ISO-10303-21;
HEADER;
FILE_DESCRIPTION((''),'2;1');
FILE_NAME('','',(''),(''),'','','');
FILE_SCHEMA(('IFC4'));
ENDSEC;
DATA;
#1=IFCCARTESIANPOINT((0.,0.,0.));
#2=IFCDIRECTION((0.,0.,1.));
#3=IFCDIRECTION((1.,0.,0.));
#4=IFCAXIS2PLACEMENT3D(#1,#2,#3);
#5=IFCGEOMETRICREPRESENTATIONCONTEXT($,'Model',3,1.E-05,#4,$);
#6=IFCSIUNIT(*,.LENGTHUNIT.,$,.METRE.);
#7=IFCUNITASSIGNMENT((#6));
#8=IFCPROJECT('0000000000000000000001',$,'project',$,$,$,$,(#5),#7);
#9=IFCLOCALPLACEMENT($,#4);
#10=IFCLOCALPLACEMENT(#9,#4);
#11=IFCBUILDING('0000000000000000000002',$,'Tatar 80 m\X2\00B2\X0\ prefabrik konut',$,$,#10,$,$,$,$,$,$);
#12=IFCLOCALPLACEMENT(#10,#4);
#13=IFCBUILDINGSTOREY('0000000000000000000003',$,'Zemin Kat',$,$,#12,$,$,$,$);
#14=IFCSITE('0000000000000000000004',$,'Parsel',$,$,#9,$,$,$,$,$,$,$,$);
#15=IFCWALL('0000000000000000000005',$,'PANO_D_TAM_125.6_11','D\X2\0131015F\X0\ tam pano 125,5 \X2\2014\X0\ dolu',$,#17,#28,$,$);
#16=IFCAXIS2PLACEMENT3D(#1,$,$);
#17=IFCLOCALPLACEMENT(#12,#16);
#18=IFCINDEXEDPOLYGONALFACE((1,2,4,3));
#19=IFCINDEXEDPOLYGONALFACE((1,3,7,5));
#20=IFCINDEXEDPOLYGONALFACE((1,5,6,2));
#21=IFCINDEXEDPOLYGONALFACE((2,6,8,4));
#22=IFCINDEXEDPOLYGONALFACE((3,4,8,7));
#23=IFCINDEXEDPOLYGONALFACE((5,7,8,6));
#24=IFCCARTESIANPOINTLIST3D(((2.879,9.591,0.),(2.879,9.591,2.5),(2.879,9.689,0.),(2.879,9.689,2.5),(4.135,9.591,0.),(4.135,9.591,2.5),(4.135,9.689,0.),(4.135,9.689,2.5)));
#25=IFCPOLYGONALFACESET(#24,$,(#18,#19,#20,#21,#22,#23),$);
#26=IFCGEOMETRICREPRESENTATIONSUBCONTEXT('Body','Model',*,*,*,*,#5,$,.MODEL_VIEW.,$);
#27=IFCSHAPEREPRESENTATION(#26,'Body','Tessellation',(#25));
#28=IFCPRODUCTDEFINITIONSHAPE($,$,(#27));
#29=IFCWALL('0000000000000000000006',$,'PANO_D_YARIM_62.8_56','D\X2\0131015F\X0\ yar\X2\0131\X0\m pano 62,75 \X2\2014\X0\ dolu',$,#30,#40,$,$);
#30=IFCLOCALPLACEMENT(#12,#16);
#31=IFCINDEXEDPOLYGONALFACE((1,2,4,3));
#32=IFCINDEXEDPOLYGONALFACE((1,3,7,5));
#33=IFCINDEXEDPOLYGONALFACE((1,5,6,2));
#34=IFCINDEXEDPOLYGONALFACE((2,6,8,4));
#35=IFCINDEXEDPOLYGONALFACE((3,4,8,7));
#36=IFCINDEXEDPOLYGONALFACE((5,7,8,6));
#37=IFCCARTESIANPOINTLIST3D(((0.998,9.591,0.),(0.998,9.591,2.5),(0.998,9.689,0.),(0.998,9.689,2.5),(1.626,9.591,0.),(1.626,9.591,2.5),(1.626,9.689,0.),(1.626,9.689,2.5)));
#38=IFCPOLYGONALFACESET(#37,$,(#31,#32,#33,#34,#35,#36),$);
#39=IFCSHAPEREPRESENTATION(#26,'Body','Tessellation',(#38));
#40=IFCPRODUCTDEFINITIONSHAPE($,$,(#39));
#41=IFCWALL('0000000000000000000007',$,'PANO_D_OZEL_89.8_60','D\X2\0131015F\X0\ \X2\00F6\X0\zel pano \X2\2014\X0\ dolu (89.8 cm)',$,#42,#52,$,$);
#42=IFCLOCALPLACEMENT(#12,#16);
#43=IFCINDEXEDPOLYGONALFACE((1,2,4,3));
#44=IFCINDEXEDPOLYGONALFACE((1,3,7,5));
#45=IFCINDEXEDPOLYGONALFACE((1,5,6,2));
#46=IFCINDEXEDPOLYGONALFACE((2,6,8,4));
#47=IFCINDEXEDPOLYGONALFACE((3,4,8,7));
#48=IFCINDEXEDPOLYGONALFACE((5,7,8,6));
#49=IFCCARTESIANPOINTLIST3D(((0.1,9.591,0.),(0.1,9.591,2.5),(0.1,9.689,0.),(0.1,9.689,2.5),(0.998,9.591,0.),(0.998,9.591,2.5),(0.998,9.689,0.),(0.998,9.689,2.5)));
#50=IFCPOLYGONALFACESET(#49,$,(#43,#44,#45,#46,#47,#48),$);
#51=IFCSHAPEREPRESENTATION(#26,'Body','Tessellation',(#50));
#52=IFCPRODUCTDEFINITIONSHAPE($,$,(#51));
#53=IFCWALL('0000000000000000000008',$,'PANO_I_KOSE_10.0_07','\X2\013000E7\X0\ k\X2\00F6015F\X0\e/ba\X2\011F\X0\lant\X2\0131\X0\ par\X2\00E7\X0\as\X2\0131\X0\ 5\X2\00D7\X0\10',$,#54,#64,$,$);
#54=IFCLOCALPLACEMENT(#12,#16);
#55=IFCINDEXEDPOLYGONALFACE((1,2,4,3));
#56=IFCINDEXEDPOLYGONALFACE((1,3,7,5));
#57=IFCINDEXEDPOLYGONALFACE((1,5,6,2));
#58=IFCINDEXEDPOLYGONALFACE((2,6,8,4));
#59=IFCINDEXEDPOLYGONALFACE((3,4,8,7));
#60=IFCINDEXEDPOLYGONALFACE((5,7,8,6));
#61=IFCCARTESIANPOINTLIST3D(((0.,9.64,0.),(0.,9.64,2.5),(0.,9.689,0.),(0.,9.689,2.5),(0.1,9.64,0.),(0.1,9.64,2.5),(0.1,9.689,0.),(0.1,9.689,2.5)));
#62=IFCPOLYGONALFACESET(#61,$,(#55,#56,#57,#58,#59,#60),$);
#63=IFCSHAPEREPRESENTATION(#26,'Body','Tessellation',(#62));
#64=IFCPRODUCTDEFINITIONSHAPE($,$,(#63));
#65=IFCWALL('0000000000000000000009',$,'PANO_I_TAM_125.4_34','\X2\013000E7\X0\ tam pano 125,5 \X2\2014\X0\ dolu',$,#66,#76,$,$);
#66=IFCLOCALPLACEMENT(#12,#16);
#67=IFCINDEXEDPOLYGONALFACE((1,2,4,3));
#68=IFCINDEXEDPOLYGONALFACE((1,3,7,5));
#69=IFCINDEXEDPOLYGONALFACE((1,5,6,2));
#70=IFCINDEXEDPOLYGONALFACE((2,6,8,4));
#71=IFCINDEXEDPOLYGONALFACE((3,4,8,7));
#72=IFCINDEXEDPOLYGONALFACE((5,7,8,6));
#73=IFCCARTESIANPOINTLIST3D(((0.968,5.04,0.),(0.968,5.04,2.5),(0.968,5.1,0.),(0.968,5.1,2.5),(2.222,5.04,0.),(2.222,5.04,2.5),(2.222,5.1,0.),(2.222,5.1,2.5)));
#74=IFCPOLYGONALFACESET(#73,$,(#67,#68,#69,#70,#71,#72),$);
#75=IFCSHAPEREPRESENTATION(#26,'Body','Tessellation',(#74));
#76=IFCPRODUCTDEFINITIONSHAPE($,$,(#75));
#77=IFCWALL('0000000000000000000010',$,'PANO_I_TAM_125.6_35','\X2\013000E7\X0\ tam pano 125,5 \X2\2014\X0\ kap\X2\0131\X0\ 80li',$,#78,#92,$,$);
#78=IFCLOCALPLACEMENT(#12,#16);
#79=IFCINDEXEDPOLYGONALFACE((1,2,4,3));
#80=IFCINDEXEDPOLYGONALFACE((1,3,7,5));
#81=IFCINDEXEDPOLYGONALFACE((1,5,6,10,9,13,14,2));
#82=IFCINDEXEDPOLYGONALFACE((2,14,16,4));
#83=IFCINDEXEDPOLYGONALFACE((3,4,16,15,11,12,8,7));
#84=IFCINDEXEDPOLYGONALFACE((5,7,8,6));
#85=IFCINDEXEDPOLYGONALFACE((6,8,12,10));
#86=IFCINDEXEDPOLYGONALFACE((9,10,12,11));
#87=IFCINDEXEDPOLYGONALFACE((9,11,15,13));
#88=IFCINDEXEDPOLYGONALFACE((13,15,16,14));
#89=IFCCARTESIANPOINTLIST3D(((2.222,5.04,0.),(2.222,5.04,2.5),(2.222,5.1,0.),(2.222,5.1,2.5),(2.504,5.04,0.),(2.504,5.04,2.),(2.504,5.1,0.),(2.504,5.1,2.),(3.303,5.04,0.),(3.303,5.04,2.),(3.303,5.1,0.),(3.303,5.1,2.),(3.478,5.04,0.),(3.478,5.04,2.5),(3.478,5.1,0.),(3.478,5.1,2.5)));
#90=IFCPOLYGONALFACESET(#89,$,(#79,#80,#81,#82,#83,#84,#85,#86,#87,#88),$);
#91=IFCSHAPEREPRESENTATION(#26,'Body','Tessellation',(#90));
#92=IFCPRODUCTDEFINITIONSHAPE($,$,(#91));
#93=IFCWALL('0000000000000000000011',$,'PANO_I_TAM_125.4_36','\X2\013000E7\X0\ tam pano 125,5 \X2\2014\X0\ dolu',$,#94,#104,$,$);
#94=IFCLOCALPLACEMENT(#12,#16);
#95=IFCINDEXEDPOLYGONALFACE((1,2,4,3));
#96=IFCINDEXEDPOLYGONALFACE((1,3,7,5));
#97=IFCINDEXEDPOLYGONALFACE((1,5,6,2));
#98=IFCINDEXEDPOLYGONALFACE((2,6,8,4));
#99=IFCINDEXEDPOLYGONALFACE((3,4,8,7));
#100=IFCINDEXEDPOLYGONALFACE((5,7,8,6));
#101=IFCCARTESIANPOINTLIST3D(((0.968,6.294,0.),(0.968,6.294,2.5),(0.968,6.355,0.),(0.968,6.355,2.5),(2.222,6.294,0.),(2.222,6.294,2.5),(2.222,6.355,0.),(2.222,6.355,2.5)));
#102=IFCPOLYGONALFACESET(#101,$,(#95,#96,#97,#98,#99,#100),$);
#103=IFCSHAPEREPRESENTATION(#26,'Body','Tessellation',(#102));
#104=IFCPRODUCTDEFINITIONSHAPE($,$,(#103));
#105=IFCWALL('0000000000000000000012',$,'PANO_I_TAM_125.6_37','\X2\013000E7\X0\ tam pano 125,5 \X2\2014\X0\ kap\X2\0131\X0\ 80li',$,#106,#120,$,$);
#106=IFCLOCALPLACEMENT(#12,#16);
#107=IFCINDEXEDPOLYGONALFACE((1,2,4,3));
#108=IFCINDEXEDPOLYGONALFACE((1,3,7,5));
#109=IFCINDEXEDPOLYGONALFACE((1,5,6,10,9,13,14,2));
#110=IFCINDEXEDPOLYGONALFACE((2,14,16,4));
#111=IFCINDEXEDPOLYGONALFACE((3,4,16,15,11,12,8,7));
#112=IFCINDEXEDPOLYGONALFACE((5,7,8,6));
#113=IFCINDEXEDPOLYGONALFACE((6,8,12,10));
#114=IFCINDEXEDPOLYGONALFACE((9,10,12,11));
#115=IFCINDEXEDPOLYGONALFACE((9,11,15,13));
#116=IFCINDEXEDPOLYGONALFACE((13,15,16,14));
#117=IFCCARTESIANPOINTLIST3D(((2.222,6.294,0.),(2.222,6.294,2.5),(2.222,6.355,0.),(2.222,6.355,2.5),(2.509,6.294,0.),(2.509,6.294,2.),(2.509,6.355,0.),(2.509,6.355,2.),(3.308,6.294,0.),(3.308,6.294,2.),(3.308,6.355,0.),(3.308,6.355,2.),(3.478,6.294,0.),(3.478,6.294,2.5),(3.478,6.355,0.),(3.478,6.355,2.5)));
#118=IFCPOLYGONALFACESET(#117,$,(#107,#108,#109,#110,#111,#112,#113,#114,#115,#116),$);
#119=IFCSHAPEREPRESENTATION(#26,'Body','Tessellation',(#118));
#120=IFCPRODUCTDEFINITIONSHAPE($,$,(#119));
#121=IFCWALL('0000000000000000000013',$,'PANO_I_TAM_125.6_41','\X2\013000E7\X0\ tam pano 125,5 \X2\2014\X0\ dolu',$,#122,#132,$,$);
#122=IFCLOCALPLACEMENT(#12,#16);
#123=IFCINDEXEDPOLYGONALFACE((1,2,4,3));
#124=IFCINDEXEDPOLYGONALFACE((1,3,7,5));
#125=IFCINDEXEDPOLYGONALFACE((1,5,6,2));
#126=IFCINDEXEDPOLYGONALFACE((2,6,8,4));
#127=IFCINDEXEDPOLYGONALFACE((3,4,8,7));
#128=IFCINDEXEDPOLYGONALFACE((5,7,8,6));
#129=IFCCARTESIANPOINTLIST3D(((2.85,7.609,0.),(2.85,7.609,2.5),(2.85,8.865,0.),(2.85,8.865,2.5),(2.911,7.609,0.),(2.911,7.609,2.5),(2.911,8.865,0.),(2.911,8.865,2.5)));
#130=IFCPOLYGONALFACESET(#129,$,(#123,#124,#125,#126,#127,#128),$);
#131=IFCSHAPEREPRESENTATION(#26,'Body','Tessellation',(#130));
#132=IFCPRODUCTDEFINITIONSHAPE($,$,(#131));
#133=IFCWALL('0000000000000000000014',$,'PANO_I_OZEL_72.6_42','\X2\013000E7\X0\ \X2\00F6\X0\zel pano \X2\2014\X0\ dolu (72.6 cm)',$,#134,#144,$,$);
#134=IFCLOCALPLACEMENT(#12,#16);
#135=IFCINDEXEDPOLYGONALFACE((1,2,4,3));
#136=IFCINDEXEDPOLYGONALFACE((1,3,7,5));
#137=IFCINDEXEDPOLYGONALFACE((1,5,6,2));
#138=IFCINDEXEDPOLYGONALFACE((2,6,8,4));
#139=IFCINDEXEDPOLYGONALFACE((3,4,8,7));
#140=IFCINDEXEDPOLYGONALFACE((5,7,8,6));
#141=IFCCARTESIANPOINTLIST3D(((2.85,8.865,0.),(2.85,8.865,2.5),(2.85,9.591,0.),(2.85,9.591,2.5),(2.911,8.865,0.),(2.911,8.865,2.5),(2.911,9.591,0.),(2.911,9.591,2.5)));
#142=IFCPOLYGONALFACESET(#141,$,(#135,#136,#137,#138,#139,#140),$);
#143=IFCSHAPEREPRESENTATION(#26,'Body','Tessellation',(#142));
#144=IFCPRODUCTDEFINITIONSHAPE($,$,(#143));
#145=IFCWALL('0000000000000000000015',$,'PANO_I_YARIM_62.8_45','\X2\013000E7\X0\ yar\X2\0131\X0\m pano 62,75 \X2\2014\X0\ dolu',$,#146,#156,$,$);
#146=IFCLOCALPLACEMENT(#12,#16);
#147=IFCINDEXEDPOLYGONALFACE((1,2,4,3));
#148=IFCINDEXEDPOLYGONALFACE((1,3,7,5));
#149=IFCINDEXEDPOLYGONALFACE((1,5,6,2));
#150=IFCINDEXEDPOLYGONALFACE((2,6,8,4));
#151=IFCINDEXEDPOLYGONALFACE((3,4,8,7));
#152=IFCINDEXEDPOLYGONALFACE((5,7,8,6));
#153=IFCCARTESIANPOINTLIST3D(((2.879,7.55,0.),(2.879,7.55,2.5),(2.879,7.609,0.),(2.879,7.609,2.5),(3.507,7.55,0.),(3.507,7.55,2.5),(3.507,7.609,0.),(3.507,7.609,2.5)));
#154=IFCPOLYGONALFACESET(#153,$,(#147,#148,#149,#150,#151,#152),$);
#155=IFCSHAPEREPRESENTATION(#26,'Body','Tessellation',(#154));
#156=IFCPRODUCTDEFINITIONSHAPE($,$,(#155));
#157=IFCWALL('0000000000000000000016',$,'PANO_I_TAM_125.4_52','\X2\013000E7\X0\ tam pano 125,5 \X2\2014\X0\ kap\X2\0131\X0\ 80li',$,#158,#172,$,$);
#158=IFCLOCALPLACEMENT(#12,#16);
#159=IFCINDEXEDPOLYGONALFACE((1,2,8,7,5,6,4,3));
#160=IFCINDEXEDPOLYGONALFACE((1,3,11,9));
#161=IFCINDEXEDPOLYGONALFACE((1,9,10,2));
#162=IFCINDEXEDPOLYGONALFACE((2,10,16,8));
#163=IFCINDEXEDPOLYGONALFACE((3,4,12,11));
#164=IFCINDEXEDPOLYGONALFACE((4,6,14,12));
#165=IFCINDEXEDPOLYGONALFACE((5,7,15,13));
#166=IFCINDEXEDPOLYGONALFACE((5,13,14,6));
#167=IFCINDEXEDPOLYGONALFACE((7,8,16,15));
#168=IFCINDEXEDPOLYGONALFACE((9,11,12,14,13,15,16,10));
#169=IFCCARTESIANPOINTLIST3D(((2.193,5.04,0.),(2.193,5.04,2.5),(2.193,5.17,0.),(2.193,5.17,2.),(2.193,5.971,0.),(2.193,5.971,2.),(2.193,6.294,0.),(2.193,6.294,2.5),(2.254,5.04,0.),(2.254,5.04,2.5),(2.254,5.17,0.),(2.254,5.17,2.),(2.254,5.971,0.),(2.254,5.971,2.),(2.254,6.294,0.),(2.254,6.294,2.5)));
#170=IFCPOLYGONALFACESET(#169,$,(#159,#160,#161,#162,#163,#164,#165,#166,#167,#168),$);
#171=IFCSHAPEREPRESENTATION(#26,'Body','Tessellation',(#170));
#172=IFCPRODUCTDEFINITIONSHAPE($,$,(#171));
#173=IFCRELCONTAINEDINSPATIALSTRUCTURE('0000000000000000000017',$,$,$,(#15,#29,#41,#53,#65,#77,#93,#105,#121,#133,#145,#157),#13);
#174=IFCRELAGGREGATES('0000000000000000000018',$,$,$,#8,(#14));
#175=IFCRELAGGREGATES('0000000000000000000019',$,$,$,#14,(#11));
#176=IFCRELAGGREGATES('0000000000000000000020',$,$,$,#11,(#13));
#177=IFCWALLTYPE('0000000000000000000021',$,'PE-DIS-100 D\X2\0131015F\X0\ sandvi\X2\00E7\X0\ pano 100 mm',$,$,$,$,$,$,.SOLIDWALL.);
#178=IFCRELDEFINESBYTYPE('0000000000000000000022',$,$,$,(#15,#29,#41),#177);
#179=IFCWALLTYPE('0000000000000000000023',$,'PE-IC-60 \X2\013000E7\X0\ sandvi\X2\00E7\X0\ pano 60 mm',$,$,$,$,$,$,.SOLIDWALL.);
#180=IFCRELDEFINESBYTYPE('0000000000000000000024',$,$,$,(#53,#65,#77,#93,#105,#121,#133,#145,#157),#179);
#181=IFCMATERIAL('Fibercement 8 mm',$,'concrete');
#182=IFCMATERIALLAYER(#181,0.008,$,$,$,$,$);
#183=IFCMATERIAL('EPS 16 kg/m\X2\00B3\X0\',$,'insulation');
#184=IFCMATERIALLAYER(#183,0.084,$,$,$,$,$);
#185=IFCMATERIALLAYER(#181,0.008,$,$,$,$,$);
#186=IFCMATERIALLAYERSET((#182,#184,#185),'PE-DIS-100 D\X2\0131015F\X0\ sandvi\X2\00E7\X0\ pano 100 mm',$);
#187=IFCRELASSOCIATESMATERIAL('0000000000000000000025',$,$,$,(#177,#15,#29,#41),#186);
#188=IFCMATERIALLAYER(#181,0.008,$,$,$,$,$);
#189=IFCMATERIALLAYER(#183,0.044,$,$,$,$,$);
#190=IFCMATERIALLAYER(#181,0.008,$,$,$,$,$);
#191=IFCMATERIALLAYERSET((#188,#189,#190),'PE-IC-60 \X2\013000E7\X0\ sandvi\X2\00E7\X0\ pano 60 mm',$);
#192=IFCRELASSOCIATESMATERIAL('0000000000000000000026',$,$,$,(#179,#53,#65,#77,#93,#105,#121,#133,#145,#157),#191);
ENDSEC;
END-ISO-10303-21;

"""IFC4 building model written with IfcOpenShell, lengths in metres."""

from ifc_helpers import new_model, si_unit, frame, origin_with_axes, place, context, subcontext, project, spatial, line, indexed_curve, outline, extrude, material, layer, layer_set, layer_usage, type_object, element, save


model = new_model("IFC4")

# Units and contexts
model_context = context("Model", 3, precision=1e-05, world=origin_with_axes())
body_context = subcontext(model_context, "Body", "Model", "MODEL_VIEW")
ifc_project = project(units=[si_unit("LENGTHUNIT", "METRE")], contexts=[model_context])

# Site, building, storey
site_placement = place(None, origin_with_axes())
site = spatial("IfcSite", under=ifc_project, at=site_placement, Name="Parsel")
building_placement = place(site_placement, origin_with_axes())
building = spatial("IfcBuilding", under=site, at=building_placement, Name="Tatar 80 m² prefabrik konut")
storey_placement = place(building_placement, origin_with_axes())
storey = spatial("IfcBuildingStorey", under=building, at=storey_placement, Name="Zemin Kat")

# Shared definitions
ifc_material_1 = material(Name="Fibercement 8 mm", Category="concrete")
ifc_layer_1 = layer(ifc_material_1, 0.008)
ifc_material_2 = material(Name="EPS 16 kg/m³", Category="insulation")
ifc_layer_2 = layer(ifc_material_2, 0.084)
ifc_layer_3 = layer(ifc_material_1, 0.008)
ifc_layer_set_1 = layer_set([ifc_layer_1, ifc_layer_2, ifc_layer_3], Name="PE-DIS-100 Dış sandviç pano 100 mm")
wall_type_1 = type_object("IfcWallType", Name="PE-DIS-100 Dış sandviç pano 100 mm", PredefinedType="SOLIDWALL", material=ifc_layer_set_1)

# Walls
ifc_layer_usage_1 = layer_usage(ifc_layer_set_1, "AXIS2", "POSITIVE", 0.0)
wall_1_placement = place(storey_placement, frame((2.879, 9.591, 0.0), z_axis=(0.0, 0.0, 1.0), x_axis=(1.0, 0.0, 0.0)))
element("IfcWall", 1, at=wall_1_placement, inside=storey, type_object=wall_type_1, material=ifc_layer_usage_1, Name="PANO_D_TAM_125.6_11", Description="Dış tam pano 125,5 — dolu", context=body_context, shape_type="SweptSolid", body=[
    extrude(outline(indexed_curve([(0.0, 0.0), (1.256, 0.0), (1.256, 0.098), (0.0, 0.098)], segments=[line(1, 2, 3, 4, 1)])), origin_with_axes(), (0.0, 0.0, 1.0), 2.5),
])
ifc_layer_usage_2 = layer_usage(ifc_layer_set_1, "AXIS2", "POSITIVE", 0.0)
wall_2_placement = place(storey_placement, frame((0.998, 9.591, 0.0), z_axis=(0.0, 0.0, 1.0), x_axis=(1.0, 0.0, 0.0)))
element("IfcWall", 2, at=wall_2_placement, inside=storey, type_object=wall_type_1, material=ifc_layer_usage_2, Name="PANO_D_YARIM_62.8_56", Description="Dış yarım pano 62,75 — dolu", context=body_context, shape_type="SweptSolid", body=[
    extrude(outline(indexed_curve([(0.0, 0.0), (0.628, 0.0), (0.628, 0.098), (0.0, 0.098)], segments=[line(1, 2, 3, 4, 1)])), origin_with_axes(), (0.0, 0.0, 1.0), 2.5),
])
ifc_layer_usage_3 = layer_usage(ifc_layer_set_1, "AXIS2", "POSITIVE", 0.0)
wall_3_placement = place(storey_placement, frame((0.1, 9.591, 0.0), z_axis=(0.0, 0.0, 1.0), x_axis=(1.0, 0.0, 0.0)))
element("IfcWall", 3, at=wall_3_placement, inside=storey, type_object=wall_type_1, material=ifc_layer_usage_3, Name="PANO_D_OZEL_89.8_60", Description="Dış özel pano — dolu (89.8 cm)", context=body_context, shape_type="SweptSolid", body=[
    extrude(outline(indexed_curve([(0.0, 0.0), (0.898, 0.0), (0.898, 0.098), (0.0, 0.098)], segments=[line(1, 2, 3, 4, 1)])), origin_with_axes(), (0.0, 0.0, 1.0), 2.5),
])
ifc_layer_4 = layer(ifc_material_1, 0.008)
ifc_layer_5 = layer(ifc_material_2, 0.044)
ifc_layer_6 = layer(ifc_material_1, 0.008)
ifc_layer_set_2 = layer_set([ifc_layer_4, ifc_layer_5, ifc_layer_6], Name="PE-IC-60 İç sandviç pano 60 mm")
ifc_layer_usage_4 = layer_usage(ifc_layer_set_2, "AXIS2", "POSITIVE", 0.0)
wall_type_2 = type_object("IfcWallType", Name="PE-IC-60 İç sandviç pano 60 mm", PredefinedType="SOLIDWALL", material=ifc_layer_set_2)
wall_4_placement = place(storey_placement, frame((0.0, 9.64, 0.0), z_axis=(0.0, 0.0, 1.0), x_axis=(1.0, 0.0, 0.0)))
element("IfcWall", 4, at=wall_4_placement, inside=storey, type_object=wall_type_2, material=ifc_layer_usage_4, Name="PANO_I_KOSE_10.0_07", Description="İç köşe/bağlantı parçası 5×10", context=body_context, shape_type="SweptSolid", body=[
    extrude(outline(indexed_curve([(0.0, 0.0), (0.1, 0.0), (0.1, 0.049), (0.0, 0.049)], segments=[line(1, 2, 3, 4, 1)])), origin_with_axes(), (0.0, 0.0, 1.0), 2.5),
])
ifc_layer_usage_5 = layer_usage(ifc_layer_set_2, "AXIS2", "POSITIVE", 0.0)
wall_5_placement = place(storey_placement, frame((0.968, 5.04, 0.0), z_axis=(0.0, 0.0, 1.0), x_axis=(1.0, 0.0, 0.0)))
element("IfcWall", 5, at=wall_5_placement, inside=storey, type_object=wall_type_2, material=ifc_layer_usage_5, Name="PANO_I_TAM_125.4_34", Description="İç tam pano 125,5 — dolu", context=body_context, shape_type="SweptSolid", body=[
    extrude(outline(indexed_curve([(0.0, 0.0), (1.254, 0.0), (1.254, 0.06), (0.0, 0.06)], segments=[line(1, 2, 3, 4, 1)])), origin_with_axes(), (0.0, 0.0, 1.0), 2.5),
])

# Wall, opening
ifc_layer_usage_6 = layer_usage(ifc_layer_set_2, "AXIS2", "POSITIVE", 0.0)
wall_6_placement = place(storey_placement, frame((2.222, 5.04, 0.0), z_axis=(0.0, 0.0, 1.0), x_axis=(1.0, 0.0, 0.0)))
wall_6 = element("IfcWall", 6, at=wall_6_placement, inside=storey, type_object=wall_type_2, material=ifc_layer_usage_6, Name="PANO_I_TAM_125.6_35", Description="İç tam pano 125,5 — kapı 80li", context=body_context, shape_type="SweptSolid", body=[
    extrude(outline(indexed_curve([(0.0, 0.0), (1.256, 0.0), (1.256, 0.06), (0.0, 0.06)], segments=[line(1, 2, 3, 4, 1)])), origin_with_axes(), (0.0, 0.0, 1.0), 2.5),
])
opening_1_placement = place(wall_6_placement, origin_with_axes())
element("IfcOpeningElement", 7, at=opening_1_placement, cuts=wall_6, PredefinedType="OPENING", context=body_context, shape_type="SweptSolid", body=[
    extrude(outline(indexed_curve([(0.0, 0.0), (0.799, 0.0), (0.799, 0.1), (0.0, 0.1)], segments=[line(1, 2, 3, 4, 1)])), frame((0.282, -0.02, 0.0), z_axis=(0.0, 0.0, 1.0), x_axis=(1.0, 0.0, 0.0)), (0.0, 0.0, 1.0), 2.0),
])

# Wall
ifc_layer_usage_7 = layer_usage(ifc_layer_set_2, "AXIS2", "POSITIVE", 0.0)
wall_7_placement = place(storey_placement, frame((0.968, 6.294, 0.0), z_axis=(0.0, 0.0, 1.0), x_axis=(1.0, 0.0, 0.0)))
element("IfcWall", 8, at=wall_7_placement, inside=storey, type_object=wall_type_2, material=ifc_layer_usage_7, Name="PANO_I_TAM_125.4_36", Description="İç tam pano 125,5 — dolu", context=body_context, shape_type="SweptSolid", body=[
    extrude(outline(indexed_curve([(0.0, 0.0), (1.254, 0.0), (1.254, 0.061), (0.0, 0.061)], segments=[line(1, 2, 3, 4, 1)])), origin_with_axes(), (0.0, 0.0, 1.0), 2.5),
])

# Wall, opening
ifc_layer_usage_8 = layer_usage(ifc_layer_set_2, "AXIS2", "POSITIVE", 0.0)
wall_8_placement = place(storey_placement, frame((2.222, 6.294, 0.0), z_axis=(0.0, 0.0, 1.0), x_axis=(1.0, 0.0, 0.0)))
wall_8 = element("IfcWall", 9, at=wall_8_placement, inside=storey, type_object=wall_type_2, material=ifc_layer_usage_8, Name="PANO_I_TAM_125.6_37", Description="İç tam pano 125,5 — kapı 80li", context=body_context, shape_type="SweptSolid", body=[
    extrude(outline(indexed_curve([(0.0, 0.0), (1.256, 0.0), (1.256, 0.061), (0.0, 0.061)], segments=[line(1, 2, 3, 4, 1)])), origin_with_axes(), (0.0, 0.0, 1.0), 2.5),
])
opening_2_placement = place(wall_8_placement, origin_with_axes())
element("IfcOpeningElement", 10, at=opening_2_placement, cuts=wall_8, PredefinedType="OPENING", context=body_context, shape_type="SweptSolid", body=[
    extrude(outline(indexed_curve([(0.0, 0.0), (0.799, 0.0), (0.799, 0.101), (0.0, 0.101)], segments=[line(1, 2, 3, 4, 1)])), frame((0.287, -0.02, 0.0), z_axis=(0.0, 0.0, 1.0), x_axis=(1.0, 0.0, 0.0)), (0.0, 0.0, 1.0), 2.0),
])

# Walls
ifc_layer_usage_9 = layer_usage(ifc_layer_set_2, "AXIS2", "POSITIVE", 0.0)
wall_9_placement = place(storey_placement, frame((2.911, 7.609, 0.0), z_axis=(0.0, 0.0, 1.0), x_axis=(0.0, 1.0, 0.0)))
element("IfcWall", 11, at=wall_9_placement, inside=storey, type_object=wall_type_2, material=ifc_layer_usage_9, Name="PANO_I_TAM_125.6_41", Description="İç tam pano 125,5 — dolu", context=body_context, shape_type="SweptSolid", body=[
    extrude(outline(indexed_curve([(0.0, 0.0), (1.256, 0.0), (1.256, 0.061), (0.0, 0.061)], segments=[line(1, 2, 3, 4, 1)])), origin_with_axes(), (0.0, 0.0, 1.0), 2.5),
])
ifc_layer_usage_10 = layer_usage(ifc_layer_set_2, "AXIS2", "POSITIVE", 0.0)
wall_10_placement = place(storey_placement, frame((2.911, 8.865, 0.0), z_axis=(0.0, 0.0, 1.0), x_axis=(0.0, 1.0, 0.0)))
element("IfcWall", 12, at=wall_10_placement, inside=storey, type_object=wall_type_2, material=ifc_layer_usage_10, Name="PANO_I_OZEL_72.6_42", Description="İç özel pano — dolu (72.6 cm)", context=body_context, shape_type="SweptSolid", body=[
    extrude(outline(indexed_curve([(0.0, 0.0), (0.726, 0.0), (0.726, 0.061), (0.0, 0.061)], segments=[line(1, 2, 3, 4, 1)])), origin_with_axes(), (0.0, 0.0, 1.0), 2.5),
])
ifc_layer_usage_11 = layer_usage(ifc_layer_set_2, "AXIS2", "POSITIVE", 0.0)
wall_11_placement = place(storey_placement, frame((2.879, 7.55, 0.0), z_axis=(0.0, 0.0, 1.0), x_axis=(1.0, 0.0, 0.0)))
element("IfcWall", 13, at=wall_11_placement, inside=storey, type_object=wall_type_2, material=ifc_layer_usage_11, Name="PANO_I_YARIM_62.8_45", Description="İç yarım pano 62,75 — dolu", context=body_context, shape_type="SweptSolid", body=[
    extrude(outline(indexed_curve([(0.0, 0.0), (0.628, 0.0), (0.628, 0.059), (0.0, 0.059)], segments=[line(1, 2, 3, 4, 1)])), origin_with_axes(), (0.0, 0.0, 1.0), 2.5),
])

# Wall, opening
ifc_layer_usage_12 = layer_usage(ifc_layer_set_2, "AXIS2", "POSITIVE", 0.0)
wall_12_placement = place(storey_placement, frame((2.254, 5.04, 0.0), z_axis=(0.0, 0.0, 1.0), x_axis=(0.0, 1.0, 0.0)))
wall_12 = element("IfcWall", 14, at=wall_12_placement, inside=storey, type_object=wall_type_2, material=ifc_layer_usage_12, Name="PANO_I_TAM_125.4_52", Description="İç tam pano 125,5 — kapı 80li", context=body_context, shape_type="SweptSolid", body=[
    extrude(outline(indexed_curve([(0.0, 0.0), (1.254, 0.0), (1.254, 0.061), (0.0, 0.061)], segments=[line(1, 2, 3, 4, 1)])), origin_with_axes(), (0.0, 0.0, 1.0), 2.5),
])
opening_3_placement = place(wall_12_placement, origin_with_axes())
element("IfcOpeningElement", 15, at=opening_3_placement, cuts=wall_12, PredefinedType="OPENING", context=body_context, shape_type="SweptSolid", body=[
    extrude(outline(indexed_curve([(0.0, 0.0), (0.801, 0.0), (0.801, 0.101), (0.0, 0.101)], segments=[line(1, 2, 3, 4, 1)])), frame((0.13, -0.02, 0.0), z_axis=(0.0, 0.0, 1.0), x_axis=(1.0, 0.0, 0.0)), (0.0, 0.0, 1.0), 2.0),
])

save(model, "model.ifc")
